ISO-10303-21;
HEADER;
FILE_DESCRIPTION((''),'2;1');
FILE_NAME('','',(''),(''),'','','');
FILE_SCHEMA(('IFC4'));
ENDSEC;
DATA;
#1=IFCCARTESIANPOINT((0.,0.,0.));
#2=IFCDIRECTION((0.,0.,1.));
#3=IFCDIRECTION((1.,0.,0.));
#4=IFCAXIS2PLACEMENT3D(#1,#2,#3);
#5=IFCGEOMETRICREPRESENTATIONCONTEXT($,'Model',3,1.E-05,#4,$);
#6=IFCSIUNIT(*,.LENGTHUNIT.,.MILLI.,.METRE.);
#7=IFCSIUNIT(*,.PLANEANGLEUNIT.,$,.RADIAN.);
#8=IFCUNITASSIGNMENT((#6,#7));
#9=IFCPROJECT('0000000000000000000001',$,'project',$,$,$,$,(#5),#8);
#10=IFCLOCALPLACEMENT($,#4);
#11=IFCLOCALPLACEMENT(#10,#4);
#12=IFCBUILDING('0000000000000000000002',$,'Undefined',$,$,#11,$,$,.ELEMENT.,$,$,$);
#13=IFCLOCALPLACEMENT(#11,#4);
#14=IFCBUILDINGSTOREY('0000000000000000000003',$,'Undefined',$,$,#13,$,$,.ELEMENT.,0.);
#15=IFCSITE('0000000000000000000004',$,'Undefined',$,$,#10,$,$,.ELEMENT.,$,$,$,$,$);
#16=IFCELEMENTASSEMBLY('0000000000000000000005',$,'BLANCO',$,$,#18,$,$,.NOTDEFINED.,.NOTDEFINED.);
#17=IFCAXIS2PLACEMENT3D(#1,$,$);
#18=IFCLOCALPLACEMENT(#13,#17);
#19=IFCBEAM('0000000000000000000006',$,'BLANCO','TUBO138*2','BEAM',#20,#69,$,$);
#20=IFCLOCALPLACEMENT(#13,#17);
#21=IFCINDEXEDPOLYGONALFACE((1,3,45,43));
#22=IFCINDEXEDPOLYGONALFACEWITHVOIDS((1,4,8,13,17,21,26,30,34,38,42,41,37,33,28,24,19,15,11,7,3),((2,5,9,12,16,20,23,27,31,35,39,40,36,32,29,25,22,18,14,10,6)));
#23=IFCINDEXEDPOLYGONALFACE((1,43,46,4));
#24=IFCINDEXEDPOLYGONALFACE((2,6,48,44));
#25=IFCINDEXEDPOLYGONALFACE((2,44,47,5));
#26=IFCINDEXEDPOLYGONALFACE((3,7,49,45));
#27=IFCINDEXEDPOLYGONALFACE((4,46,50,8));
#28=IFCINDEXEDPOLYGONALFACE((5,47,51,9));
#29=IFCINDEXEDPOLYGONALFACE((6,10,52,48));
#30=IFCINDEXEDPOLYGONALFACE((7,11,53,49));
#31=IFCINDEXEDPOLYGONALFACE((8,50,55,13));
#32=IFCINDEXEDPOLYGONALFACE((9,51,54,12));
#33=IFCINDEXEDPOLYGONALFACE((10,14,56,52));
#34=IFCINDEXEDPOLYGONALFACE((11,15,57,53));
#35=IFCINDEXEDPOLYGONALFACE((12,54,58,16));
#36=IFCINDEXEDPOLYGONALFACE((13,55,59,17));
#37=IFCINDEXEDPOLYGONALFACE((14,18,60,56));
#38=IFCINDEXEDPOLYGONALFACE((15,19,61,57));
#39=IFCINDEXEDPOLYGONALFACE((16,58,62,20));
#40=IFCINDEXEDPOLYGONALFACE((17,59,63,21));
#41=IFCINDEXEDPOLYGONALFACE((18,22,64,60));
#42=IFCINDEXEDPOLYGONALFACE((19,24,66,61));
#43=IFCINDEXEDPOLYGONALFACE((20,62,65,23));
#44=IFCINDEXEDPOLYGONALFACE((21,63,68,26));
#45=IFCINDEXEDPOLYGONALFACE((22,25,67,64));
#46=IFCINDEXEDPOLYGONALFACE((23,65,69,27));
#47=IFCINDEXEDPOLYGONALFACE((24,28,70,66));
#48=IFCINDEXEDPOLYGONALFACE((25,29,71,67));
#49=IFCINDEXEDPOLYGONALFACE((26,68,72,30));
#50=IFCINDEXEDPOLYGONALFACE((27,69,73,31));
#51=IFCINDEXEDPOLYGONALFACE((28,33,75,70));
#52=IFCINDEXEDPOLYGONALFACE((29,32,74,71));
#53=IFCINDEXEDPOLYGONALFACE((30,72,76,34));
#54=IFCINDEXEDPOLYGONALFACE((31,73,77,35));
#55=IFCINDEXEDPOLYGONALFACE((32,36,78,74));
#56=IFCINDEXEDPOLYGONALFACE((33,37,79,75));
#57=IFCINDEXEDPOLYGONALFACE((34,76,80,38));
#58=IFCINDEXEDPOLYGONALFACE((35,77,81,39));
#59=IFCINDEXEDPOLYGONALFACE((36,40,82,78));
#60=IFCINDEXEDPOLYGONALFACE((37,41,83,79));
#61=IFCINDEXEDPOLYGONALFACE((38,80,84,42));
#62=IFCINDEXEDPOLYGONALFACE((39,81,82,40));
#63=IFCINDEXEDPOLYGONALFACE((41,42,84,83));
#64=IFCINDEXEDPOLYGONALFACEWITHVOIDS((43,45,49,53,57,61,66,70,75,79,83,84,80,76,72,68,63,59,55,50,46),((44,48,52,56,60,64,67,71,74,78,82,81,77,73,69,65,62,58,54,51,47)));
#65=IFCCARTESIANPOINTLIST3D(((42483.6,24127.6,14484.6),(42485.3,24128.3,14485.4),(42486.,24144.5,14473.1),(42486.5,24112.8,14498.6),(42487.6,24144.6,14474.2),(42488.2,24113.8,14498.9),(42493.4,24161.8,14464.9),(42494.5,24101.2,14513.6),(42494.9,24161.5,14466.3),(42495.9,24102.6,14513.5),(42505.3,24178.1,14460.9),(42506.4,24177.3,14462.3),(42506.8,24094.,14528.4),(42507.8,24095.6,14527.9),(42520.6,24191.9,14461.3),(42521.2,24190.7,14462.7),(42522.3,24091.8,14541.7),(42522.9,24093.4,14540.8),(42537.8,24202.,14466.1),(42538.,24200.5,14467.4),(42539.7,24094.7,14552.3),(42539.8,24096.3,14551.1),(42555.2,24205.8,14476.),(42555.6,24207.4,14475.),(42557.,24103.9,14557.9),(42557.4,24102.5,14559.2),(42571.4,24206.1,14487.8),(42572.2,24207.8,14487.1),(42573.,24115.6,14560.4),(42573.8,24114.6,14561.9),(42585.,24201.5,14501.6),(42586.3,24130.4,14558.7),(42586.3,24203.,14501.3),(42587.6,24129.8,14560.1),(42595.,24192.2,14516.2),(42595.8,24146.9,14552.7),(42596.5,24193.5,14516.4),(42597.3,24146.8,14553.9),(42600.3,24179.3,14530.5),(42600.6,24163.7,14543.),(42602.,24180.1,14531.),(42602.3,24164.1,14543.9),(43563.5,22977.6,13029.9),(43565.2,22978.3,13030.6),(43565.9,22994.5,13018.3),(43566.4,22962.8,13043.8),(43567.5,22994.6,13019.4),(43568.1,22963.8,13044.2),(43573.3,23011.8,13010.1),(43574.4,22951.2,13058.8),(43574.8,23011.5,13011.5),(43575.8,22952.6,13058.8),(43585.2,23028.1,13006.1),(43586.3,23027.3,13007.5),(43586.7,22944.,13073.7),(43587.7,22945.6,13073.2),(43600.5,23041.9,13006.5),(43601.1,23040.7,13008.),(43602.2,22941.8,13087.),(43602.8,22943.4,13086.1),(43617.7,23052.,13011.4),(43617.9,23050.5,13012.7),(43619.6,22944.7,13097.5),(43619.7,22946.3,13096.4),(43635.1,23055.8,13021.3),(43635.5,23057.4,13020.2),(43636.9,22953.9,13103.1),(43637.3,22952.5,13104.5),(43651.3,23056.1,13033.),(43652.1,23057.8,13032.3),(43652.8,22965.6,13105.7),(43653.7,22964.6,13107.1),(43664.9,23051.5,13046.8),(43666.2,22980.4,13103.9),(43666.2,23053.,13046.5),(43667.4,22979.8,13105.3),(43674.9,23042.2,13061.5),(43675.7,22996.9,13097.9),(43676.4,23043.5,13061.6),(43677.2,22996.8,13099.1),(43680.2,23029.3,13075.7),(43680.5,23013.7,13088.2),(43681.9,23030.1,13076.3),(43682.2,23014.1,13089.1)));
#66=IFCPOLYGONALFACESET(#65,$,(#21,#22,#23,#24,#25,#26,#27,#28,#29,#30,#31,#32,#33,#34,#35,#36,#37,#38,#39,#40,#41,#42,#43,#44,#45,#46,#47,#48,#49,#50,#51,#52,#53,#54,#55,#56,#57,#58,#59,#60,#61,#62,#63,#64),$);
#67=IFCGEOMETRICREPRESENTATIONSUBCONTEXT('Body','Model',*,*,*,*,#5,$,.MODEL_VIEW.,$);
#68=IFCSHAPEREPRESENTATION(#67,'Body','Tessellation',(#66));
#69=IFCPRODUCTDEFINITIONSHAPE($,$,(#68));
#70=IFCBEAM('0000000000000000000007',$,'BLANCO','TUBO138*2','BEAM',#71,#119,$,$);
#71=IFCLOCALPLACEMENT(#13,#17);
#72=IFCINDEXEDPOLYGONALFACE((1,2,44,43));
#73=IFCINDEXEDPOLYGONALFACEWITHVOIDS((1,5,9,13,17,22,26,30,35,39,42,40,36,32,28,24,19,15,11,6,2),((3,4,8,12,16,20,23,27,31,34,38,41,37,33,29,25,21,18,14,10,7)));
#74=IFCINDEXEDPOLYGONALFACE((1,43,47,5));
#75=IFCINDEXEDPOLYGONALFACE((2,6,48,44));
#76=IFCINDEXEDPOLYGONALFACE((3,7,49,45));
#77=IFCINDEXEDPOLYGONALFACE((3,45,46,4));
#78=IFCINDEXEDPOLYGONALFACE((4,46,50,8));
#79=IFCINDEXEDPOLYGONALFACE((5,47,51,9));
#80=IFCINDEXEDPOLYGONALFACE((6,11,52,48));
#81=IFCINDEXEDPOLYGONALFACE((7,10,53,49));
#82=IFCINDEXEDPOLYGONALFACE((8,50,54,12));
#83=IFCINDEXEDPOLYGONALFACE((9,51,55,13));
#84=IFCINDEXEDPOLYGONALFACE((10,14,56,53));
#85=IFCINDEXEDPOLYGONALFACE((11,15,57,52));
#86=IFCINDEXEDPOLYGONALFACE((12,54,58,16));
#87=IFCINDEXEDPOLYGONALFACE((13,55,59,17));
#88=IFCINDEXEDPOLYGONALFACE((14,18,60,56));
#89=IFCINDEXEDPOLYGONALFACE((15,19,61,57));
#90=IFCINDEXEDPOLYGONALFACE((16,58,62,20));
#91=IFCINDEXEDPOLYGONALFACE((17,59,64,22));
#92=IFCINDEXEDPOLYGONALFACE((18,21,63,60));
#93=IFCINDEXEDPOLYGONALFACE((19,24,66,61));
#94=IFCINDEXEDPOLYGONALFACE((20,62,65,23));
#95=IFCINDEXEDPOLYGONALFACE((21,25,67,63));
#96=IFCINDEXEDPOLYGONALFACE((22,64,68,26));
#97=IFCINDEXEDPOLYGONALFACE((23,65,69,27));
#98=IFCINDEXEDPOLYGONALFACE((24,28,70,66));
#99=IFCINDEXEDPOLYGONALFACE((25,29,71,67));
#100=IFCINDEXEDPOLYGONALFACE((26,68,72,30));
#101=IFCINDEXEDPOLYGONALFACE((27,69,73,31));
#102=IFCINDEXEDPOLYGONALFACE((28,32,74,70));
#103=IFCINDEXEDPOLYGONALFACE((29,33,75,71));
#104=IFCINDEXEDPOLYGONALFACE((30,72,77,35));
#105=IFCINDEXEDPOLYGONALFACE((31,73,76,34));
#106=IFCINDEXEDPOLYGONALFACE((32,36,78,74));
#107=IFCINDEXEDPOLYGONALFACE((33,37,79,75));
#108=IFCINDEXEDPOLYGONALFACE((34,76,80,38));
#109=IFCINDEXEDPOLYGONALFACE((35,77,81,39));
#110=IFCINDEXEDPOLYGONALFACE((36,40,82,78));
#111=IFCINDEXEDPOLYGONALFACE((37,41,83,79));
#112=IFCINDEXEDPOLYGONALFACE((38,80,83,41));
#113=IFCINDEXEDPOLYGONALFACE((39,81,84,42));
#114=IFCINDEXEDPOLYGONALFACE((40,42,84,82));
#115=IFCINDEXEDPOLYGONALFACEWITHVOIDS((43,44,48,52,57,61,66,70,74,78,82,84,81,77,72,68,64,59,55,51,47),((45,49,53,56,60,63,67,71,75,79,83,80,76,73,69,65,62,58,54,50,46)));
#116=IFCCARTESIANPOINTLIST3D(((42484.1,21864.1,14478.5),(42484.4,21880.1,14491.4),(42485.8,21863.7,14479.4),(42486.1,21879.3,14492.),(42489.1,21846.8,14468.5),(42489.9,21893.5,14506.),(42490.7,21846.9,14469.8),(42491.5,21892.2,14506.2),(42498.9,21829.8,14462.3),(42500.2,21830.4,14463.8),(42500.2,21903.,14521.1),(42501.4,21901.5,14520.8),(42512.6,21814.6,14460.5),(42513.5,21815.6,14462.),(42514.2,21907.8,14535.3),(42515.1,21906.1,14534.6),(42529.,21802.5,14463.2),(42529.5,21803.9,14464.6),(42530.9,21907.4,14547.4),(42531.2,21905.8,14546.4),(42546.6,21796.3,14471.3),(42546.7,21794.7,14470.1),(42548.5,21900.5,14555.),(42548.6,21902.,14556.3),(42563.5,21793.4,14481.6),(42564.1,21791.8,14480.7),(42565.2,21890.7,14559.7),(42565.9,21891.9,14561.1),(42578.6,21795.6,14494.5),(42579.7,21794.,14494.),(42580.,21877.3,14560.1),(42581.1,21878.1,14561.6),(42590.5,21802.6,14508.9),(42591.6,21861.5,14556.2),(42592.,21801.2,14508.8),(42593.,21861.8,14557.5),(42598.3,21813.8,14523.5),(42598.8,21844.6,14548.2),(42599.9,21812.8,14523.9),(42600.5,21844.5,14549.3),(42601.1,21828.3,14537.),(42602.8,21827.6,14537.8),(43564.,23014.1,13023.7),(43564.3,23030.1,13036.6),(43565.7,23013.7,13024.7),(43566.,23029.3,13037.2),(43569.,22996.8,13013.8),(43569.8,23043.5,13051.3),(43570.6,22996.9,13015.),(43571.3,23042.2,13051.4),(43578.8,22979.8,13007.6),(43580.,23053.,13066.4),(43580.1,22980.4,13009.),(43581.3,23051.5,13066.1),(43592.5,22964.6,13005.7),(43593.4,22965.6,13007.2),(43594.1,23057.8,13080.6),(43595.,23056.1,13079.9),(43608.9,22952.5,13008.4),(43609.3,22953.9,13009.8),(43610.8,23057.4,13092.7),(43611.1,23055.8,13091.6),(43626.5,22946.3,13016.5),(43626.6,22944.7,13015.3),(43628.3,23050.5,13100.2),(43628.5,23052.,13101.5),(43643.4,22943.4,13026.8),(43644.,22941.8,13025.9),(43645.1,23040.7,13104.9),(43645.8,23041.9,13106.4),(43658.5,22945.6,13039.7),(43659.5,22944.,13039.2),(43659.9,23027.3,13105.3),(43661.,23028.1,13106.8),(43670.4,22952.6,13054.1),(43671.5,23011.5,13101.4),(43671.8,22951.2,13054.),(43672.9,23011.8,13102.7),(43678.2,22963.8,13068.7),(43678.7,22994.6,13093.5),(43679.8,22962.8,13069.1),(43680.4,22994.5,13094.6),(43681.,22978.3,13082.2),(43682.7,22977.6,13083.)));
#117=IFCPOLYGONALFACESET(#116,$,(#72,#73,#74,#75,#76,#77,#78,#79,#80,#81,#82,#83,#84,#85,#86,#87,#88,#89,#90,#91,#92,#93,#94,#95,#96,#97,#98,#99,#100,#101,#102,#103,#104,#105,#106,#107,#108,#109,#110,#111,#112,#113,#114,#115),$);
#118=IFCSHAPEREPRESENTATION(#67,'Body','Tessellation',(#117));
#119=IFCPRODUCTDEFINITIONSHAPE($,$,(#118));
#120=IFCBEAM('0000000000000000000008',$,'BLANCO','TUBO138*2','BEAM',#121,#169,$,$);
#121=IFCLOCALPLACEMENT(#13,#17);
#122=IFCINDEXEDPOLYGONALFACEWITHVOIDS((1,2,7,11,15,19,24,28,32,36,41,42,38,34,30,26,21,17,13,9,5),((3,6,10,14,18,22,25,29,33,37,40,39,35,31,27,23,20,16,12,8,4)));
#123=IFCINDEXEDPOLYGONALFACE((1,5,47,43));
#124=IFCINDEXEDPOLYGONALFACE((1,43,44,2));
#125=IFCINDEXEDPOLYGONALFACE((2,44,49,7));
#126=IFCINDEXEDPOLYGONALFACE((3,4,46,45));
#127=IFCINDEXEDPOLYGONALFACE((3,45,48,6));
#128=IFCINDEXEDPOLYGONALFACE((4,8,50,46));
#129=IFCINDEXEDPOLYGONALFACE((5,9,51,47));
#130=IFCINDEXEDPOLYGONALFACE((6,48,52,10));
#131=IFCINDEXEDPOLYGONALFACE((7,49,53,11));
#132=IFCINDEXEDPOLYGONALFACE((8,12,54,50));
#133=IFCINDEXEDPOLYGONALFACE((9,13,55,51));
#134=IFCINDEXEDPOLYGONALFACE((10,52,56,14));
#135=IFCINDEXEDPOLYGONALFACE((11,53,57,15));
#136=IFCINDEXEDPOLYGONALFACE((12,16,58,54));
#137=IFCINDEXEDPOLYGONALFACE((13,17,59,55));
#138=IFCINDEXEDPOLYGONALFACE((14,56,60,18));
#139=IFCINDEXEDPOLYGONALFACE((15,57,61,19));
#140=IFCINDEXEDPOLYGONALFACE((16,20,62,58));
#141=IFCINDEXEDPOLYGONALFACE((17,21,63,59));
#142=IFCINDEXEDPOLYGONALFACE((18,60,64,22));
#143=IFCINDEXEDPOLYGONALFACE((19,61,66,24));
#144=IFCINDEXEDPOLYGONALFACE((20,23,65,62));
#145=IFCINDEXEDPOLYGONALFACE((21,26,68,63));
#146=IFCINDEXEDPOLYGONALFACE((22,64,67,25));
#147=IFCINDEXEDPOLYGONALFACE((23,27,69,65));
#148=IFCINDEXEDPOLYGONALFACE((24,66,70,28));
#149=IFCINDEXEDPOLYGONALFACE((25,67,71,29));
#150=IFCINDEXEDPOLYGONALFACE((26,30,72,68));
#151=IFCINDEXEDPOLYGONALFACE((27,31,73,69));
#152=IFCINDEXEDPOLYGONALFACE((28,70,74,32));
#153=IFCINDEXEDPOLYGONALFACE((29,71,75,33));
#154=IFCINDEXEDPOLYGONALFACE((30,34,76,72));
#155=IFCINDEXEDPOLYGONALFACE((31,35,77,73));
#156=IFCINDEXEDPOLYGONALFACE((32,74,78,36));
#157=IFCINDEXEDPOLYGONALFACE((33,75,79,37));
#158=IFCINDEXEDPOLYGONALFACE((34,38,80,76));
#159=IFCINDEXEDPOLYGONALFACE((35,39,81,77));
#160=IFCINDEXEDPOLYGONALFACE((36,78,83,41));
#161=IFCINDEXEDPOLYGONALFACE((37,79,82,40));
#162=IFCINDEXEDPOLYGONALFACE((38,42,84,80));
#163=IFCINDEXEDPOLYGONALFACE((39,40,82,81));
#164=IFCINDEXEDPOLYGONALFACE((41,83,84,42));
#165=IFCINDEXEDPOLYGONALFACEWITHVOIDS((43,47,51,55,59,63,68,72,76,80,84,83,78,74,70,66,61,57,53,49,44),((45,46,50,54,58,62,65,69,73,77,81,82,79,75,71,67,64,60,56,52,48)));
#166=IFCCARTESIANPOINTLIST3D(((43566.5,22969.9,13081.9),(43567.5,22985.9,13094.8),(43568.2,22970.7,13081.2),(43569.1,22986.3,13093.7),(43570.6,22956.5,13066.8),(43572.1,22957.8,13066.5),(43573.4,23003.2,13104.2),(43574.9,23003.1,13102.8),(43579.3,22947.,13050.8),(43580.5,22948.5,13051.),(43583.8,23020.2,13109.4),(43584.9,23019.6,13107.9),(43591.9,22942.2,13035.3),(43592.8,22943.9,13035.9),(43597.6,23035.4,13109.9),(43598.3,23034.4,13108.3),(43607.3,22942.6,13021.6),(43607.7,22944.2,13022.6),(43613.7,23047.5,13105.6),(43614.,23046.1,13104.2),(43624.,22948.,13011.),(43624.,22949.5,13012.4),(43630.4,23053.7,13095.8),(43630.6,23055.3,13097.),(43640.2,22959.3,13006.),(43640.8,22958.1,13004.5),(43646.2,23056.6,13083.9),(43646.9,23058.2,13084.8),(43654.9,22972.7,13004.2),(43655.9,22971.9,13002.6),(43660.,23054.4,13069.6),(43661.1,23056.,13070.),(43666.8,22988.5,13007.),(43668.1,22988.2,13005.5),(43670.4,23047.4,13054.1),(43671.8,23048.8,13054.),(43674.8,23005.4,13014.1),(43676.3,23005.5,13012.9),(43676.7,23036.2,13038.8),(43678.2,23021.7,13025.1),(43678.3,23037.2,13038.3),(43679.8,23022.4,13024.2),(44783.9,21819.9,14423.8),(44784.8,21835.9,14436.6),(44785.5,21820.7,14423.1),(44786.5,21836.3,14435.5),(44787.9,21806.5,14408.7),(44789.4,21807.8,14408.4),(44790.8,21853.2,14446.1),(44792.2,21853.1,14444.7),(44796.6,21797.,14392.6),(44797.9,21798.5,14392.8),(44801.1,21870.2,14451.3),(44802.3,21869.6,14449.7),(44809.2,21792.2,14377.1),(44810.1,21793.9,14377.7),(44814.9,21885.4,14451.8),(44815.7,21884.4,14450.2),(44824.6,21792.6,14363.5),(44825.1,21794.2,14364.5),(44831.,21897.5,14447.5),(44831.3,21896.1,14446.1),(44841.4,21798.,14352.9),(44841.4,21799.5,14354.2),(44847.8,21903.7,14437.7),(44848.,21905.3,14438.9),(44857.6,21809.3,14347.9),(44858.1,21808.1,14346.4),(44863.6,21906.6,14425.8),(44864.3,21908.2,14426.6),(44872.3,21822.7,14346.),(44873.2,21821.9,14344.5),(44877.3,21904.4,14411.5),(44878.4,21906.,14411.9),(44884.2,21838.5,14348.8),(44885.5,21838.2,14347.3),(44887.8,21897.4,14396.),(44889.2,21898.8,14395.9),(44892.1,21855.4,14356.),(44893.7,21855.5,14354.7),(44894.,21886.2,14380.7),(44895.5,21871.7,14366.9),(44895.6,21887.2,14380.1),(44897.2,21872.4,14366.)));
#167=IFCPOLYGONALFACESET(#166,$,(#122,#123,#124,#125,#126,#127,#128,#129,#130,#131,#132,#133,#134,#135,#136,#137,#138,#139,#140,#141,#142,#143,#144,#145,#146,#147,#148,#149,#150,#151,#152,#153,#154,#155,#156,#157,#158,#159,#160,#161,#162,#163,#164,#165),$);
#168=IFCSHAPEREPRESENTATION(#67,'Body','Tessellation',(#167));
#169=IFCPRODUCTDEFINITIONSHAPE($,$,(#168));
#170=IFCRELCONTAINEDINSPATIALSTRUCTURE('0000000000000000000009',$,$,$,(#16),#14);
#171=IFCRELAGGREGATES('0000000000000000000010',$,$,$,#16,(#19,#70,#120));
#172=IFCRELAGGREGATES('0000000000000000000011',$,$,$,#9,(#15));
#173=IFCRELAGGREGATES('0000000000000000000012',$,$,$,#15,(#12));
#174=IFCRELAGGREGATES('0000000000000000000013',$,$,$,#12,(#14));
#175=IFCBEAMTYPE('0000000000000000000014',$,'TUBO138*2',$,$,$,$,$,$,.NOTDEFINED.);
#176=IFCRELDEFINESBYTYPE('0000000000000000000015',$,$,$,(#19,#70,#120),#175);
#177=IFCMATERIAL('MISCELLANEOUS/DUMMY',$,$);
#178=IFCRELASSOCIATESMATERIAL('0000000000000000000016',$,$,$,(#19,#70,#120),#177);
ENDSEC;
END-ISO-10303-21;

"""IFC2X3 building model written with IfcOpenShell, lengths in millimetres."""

from ifc_helpers import new_model, si_unit, frame, origin_with_axes, origin_2d_with_axis, place, context, subcontext, project, spatial, hollow_circle, extrude, material, type_object, element, aggregate, save


model = new_model("IFC2X3")

# Units and contexts
model_context = context("Model", 3, precision=1e-05, world=origin_with_axes())
body_context = subcontext(model_context, "Body", "Model", "MODEL_VIEW")
ifc_project = project(units=[si_unit("LENGTHUNIT", "METRE", prefix="MILLI"), si_unit("PLANEANGLEUNIT", "RADIAN")], contexts=[model_context])

# Site, building, storey
site_placement = place(None, origin_with_axes())
site = spatial("IfcSite", under=ifc_project, at=site_placement, Name="Undefined", CompositionType="ELEMENT")
building_placement = place(site_placement, origin_with_axes())
building = spatial("IfcBuilding", under=site, at=building_placement, Name="Undefined", CompositionType="ELEMENT")
storey_placement = place(building_placement, origin_with_axes())
storey = spatial("IfcBuildingStorey", under=building, at=storey_placement, Name="Undefined", CompositionType="ELEMENT", Elevation=0.0)

# Element assembly, beams
assembly_placement = place(storey_placement, origin_with_axes())
assembly = element("IfcElementAssembly", 1, at=assembly_placement, inside=storey, Name="BLANCO", AssemblyPlace="NOTDEFINED", PredefinedType="NOTDEFINED")
ifc_material = material(Name="MISCELLANEOUS/DUMMY")
beam_type = type_object("IfcBeamType", Name="TUBO138*2", PredefinedType="NOTDEFINED")
beam_1_placement = place(assembly_placement, frame((43623.1, 23000.0, 13056.4), z_axis=(-0.497966, 0.461316, -0.734314), x_axis=(-0.503224, 0.535899, 0.677922)))
beam_1 = element("IfcBeam", 2, at=beam_1_placement, type_object=beam_type, material=ifc_material, Name="BLANCO", Description="TUBO138*2", ObjectType="BEAM", context=body_context, shape_type="SweptSolid", body=[
    extrude(hollow_circle(Radius=69.0, WallThickness=2.0, at=origin_2d_with_axis()), frame((2145.9, 0.0, 0.0), z_axis=(-1.0, 0.0, 0.0), x_axis=(0.0, -1.0, 0.0)), (0.0, 0.0, 1.0), 2145.9),
])
beam_2_placement = place(assembly_placement, frame((43623.1, 23000.0, 13056.4), z_axis=(-0.497966, -0.461316, -0.734314), x_axis=(-0.503224, -0.535899, 0.677922)))
beam_2 = element("IfcBeam", 3, at=beam_2_placement, type_object=beam_type, material=ifc_material, Name="BLANCO", Description="TUBO138*2", ObjectType="BEAM", context=body_context, shape_type="SweptSolid", body=[
    extrude(hollow_circle(Radius=69.0, WallThickness=2.0, at=origin_2d_with_axis()), frame((2145.9, 0.0, 0.0), z_axis=(-1.0, 0.0, 0.0), x_axis=(0.0, -1.0, 0.0)), (0.0, 0.0, 1.0), 2145.9),
])
beam_3_placement = place(assembly_placement, frame((43623.1, 23000.0, 13056.4), z_axis=(0.423552, -0.461316, -0.77961), x_axis=(0.567282, -0.535899, 0.625303)))
beam_3 = element("IfcBeam", 4, at=beam_3_placement, type_object=beam_type, material=ifc_material, Name="BLANCO", Description="TUBO138*2", ObjectType="BEAM", context=body_context, shape_type="SweptSolid", body=[
    extrude(hollow_circle(Radius=69.0, WallThickness=2.0, at=origin_2d_with_axis()), frame((2145.9, 0.0, 0.0), z_axis=(-1.0, 0.0, 0.0), x_axis=(0.0, -1.0, 0.0)), (0.0, 0.0, 1.0), 2145.9),
])
aggregate(assembly, [beam_1, beam_2, beam_3])

save(model, "model.ifc")
